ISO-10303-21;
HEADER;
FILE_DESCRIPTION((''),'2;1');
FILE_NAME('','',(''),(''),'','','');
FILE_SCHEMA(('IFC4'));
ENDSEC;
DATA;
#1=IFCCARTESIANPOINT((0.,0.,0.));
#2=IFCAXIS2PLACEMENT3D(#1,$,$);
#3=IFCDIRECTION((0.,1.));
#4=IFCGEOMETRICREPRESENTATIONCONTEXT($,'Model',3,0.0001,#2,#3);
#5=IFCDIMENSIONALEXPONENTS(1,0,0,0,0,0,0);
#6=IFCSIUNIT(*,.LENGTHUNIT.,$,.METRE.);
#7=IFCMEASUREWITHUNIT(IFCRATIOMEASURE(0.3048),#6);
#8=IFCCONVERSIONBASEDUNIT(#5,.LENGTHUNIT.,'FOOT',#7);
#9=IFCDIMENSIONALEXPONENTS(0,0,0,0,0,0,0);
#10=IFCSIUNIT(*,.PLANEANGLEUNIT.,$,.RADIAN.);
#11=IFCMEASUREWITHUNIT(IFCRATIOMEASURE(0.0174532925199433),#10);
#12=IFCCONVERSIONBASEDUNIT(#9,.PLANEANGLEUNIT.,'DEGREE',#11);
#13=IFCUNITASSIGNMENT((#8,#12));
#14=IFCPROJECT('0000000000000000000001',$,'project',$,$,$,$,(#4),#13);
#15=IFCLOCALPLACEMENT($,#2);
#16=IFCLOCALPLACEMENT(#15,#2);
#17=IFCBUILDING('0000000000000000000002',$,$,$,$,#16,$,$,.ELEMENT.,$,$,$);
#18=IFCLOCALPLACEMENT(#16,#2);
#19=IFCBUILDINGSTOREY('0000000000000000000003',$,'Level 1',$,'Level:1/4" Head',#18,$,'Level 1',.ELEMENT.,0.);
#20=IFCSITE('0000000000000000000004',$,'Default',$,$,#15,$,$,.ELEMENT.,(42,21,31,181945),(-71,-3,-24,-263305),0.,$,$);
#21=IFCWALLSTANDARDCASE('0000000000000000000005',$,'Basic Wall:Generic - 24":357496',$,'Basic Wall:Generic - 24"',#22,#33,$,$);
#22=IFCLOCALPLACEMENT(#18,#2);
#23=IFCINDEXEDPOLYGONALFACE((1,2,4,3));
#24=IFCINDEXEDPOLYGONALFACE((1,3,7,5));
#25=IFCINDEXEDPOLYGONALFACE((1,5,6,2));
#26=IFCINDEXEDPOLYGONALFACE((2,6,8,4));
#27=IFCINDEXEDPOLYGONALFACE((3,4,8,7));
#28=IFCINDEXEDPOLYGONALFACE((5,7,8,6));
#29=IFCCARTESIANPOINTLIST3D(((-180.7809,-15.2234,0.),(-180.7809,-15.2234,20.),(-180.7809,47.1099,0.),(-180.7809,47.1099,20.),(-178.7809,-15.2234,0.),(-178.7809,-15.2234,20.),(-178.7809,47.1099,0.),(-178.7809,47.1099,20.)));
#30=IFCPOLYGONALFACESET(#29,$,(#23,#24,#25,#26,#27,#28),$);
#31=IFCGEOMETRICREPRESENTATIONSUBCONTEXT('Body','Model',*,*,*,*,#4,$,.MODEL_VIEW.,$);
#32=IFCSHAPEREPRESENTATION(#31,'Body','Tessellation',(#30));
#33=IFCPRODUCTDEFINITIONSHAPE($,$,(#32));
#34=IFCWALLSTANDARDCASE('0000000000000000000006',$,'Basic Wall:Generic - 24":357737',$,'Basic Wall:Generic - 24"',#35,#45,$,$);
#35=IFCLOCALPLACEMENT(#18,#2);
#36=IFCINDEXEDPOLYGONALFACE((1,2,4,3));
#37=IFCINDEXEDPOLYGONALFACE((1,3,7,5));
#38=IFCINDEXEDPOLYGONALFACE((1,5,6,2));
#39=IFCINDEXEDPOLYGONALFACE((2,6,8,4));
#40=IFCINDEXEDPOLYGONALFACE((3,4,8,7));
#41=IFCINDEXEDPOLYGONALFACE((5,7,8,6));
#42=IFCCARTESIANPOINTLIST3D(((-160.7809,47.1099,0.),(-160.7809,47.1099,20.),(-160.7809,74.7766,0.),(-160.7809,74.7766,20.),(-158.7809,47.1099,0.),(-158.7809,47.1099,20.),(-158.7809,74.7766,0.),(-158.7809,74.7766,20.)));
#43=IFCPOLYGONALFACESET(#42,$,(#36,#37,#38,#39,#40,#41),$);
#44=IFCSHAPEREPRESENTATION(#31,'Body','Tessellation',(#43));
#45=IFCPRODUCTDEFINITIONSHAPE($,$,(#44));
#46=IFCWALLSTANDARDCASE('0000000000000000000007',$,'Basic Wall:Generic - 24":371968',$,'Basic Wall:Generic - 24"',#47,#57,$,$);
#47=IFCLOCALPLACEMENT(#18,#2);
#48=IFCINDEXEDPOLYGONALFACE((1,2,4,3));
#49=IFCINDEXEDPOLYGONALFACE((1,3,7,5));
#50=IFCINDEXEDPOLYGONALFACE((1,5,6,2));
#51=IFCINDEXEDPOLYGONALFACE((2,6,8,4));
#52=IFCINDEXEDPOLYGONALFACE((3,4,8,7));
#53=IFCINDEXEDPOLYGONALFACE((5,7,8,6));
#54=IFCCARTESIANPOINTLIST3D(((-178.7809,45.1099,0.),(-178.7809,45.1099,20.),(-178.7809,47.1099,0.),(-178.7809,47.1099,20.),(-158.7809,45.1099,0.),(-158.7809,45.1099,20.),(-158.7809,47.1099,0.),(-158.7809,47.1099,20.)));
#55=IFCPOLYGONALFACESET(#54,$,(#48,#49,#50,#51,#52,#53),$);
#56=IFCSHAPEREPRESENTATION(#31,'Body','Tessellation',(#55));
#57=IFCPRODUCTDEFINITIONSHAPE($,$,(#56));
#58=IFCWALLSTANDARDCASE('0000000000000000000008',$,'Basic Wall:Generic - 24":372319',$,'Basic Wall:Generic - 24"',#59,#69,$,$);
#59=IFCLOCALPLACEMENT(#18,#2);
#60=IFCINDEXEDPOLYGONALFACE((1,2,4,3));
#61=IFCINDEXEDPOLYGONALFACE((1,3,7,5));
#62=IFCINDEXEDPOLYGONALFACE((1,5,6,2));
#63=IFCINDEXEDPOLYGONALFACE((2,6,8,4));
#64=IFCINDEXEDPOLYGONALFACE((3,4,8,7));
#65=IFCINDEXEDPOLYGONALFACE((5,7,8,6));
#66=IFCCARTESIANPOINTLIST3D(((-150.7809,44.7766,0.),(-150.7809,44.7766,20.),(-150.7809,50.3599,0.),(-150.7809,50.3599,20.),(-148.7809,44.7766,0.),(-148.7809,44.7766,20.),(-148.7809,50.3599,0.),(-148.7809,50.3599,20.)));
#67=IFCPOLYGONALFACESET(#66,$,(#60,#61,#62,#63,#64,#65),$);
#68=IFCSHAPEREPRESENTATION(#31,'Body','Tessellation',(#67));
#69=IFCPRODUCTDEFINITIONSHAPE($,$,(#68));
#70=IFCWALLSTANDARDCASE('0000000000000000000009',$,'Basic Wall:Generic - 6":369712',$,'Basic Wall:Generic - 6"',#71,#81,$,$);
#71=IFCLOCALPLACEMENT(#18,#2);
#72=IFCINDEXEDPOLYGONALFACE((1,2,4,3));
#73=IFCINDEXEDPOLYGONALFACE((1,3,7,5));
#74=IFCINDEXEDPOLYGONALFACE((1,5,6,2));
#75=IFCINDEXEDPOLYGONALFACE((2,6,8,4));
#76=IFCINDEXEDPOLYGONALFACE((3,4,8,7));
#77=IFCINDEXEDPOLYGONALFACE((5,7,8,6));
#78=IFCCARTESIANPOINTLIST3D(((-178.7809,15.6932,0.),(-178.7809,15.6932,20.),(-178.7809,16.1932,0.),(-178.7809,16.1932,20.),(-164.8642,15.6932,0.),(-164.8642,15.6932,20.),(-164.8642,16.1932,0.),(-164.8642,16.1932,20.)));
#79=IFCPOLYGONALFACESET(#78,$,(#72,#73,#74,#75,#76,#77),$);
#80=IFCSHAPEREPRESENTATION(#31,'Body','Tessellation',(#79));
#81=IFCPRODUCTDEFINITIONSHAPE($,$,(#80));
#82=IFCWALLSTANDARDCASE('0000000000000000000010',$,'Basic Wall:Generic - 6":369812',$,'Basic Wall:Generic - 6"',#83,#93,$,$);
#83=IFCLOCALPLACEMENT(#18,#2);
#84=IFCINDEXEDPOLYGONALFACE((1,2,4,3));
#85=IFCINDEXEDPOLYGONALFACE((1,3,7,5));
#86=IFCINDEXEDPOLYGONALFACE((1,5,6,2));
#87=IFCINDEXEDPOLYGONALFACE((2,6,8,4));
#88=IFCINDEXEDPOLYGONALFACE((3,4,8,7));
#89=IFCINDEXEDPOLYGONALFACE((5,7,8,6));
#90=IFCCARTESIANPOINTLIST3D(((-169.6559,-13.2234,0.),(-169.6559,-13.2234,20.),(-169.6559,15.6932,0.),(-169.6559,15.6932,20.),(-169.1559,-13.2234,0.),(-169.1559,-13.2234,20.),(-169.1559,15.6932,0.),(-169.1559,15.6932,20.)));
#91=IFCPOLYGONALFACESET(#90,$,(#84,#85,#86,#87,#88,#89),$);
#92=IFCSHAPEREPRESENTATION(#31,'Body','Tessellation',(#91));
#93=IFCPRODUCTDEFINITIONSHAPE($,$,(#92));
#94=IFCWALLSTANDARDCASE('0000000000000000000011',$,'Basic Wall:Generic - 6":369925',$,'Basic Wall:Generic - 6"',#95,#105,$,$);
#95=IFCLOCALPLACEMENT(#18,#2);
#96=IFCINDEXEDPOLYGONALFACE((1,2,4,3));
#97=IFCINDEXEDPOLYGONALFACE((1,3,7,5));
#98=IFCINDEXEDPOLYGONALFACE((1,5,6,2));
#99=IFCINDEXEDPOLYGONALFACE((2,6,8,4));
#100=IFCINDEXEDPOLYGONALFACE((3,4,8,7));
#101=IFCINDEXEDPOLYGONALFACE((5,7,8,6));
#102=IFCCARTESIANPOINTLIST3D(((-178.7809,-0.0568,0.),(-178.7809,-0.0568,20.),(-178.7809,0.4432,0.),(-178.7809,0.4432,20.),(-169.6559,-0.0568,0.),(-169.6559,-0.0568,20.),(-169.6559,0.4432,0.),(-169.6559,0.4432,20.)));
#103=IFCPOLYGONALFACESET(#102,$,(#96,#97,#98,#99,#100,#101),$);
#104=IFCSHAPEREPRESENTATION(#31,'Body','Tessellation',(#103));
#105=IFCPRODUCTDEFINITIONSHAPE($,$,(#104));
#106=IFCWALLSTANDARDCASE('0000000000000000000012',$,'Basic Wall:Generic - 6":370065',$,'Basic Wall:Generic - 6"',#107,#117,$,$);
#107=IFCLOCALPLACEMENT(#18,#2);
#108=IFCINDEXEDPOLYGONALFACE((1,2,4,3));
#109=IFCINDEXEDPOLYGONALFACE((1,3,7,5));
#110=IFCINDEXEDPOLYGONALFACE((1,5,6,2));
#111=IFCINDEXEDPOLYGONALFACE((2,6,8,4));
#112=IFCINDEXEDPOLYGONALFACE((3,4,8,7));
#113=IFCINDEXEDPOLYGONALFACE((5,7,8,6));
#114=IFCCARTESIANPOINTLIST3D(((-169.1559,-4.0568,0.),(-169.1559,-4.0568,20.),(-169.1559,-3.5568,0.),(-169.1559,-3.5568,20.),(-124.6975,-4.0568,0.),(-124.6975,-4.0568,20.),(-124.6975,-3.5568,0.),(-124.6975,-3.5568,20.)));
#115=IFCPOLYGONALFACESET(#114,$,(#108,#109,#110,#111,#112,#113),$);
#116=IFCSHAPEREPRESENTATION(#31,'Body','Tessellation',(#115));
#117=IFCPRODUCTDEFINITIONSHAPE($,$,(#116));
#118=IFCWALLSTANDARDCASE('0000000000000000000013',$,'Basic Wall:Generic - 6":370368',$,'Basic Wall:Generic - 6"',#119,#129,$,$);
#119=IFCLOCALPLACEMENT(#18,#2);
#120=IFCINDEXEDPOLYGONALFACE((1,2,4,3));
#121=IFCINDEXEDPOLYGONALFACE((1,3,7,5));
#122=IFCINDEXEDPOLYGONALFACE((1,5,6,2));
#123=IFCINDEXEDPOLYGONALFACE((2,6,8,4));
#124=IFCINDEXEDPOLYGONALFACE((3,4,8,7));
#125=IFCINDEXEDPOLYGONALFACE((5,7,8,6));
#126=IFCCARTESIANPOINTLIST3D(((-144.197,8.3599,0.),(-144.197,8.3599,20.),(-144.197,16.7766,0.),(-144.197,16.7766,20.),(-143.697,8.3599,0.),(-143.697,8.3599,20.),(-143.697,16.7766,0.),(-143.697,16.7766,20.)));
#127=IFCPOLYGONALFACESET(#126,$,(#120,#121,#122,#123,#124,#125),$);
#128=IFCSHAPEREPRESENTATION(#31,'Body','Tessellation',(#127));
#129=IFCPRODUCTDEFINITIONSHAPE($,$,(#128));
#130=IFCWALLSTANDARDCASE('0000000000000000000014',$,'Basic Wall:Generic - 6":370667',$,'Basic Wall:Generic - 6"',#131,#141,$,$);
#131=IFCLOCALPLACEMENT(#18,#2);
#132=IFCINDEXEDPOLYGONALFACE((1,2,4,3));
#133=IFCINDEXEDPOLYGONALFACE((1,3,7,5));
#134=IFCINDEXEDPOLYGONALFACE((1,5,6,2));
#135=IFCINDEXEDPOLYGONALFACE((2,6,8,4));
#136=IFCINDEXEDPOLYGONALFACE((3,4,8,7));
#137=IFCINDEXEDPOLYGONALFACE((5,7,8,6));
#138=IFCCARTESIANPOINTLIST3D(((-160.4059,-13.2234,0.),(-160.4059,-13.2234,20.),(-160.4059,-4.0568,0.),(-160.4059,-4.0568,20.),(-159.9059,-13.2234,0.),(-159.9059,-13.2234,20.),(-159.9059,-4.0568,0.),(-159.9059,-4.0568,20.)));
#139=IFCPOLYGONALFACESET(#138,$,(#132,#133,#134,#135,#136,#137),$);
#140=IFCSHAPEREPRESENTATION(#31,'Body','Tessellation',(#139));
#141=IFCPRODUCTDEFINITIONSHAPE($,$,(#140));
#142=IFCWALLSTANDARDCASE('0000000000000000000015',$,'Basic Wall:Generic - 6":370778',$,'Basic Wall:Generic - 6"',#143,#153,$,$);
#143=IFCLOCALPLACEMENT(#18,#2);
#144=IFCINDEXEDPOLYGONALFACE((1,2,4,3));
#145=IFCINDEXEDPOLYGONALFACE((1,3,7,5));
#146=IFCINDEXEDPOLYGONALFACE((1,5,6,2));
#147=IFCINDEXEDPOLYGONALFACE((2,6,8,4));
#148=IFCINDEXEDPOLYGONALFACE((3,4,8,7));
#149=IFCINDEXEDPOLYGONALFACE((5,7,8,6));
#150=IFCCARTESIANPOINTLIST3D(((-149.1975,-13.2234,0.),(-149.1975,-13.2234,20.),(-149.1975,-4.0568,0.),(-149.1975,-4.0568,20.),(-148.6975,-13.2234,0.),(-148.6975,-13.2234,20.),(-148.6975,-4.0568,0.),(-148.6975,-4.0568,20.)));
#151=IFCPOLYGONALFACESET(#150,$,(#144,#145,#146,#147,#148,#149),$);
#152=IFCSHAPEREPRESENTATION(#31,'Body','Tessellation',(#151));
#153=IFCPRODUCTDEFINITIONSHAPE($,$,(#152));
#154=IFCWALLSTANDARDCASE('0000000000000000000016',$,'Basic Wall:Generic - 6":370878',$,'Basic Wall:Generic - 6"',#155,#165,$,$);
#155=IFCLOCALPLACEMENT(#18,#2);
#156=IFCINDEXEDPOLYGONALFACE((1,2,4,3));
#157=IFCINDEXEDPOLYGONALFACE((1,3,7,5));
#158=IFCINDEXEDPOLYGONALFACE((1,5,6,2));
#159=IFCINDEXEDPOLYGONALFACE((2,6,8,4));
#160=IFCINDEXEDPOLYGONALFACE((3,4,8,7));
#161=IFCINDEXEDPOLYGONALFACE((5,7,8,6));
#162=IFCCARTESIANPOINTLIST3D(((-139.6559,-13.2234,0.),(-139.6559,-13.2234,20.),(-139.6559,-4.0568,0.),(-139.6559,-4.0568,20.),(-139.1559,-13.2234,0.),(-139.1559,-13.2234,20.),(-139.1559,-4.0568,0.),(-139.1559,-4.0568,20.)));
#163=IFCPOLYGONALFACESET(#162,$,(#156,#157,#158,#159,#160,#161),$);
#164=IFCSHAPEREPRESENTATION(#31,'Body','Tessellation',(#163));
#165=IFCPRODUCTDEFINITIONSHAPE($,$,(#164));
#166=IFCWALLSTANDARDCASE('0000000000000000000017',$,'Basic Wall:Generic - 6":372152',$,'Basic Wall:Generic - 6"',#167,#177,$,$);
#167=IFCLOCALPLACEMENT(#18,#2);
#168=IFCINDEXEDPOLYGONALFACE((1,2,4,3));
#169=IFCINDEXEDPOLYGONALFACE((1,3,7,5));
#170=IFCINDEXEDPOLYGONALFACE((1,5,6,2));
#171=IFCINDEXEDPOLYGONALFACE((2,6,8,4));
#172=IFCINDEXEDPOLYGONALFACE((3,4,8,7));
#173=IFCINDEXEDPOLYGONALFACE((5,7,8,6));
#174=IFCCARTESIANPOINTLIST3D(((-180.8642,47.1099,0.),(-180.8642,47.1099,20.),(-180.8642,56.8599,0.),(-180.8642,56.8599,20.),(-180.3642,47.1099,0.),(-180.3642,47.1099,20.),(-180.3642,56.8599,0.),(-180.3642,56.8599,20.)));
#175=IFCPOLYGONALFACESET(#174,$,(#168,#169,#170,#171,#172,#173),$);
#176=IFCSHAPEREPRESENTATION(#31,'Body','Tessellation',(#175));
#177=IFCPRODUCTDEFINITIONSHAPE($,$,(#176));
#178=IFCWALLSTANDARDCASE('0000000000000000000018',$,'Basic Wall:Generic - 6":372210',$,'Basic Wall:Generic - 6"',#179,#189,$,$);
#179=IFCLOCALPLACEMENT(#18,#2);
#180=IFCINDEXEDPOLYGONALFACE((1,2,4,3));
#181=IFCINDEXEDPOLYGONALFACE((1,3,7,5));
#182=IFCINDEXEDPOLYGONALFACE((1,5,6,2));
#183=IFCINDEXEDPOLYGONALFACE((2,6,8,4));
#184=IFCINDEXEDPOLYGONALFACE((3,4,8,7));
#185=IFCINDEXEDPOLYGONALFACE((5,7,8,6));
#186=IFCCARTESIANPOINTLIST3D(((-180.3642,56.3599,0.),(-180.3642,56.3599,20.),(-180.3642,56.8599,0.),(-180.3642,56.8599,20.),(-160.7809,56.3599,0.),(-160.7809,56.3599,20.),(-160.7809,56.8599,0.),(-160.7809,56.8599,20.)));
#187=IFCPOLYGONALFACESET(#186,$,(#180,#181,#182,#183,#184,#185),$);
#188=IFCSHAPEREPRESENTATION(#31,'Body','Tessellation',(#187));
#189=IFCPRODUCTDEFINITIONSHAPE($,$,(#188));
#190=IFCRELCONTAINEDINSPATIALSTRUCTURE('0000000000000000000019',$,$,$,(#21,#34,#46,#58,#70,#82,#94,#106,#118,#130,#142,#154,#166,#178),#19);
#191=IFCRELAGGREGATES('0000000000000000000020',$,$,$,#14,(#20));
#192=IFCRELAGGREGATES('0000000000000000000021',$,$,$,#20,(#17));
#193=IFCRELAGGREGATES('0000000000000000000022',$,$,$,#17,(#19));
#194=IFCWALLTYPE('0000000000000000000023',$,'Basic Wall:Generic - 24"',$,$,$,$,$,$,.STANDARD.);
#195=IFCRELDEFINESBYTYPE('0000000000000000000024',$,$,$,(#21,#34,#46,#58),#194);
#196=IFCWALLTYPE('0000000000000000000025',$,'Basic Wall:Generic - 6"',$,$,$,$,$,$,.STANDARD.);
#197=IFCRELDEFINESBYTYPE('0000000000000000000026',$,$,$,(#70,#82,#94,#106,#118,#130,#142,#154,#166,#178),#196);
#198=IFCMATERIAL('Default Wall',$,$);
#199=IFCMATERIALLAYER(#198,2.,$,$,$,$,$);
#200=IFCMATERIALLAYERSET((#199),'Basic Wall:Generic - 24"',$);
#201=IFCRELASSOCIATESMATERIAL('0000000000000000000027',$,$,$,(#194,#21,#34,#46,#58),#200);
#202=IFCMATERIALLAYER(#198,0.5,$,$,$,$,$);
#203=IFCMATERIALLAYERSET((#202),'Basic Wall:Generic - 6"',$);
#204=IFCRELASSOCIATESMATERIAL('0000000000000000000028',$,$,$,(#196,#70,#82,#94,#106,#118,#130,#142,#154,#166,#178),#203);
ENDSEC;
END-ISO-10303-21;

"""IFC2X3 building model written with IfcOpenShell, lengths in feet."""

from ifc_helpers import new_model, entity, si_unit, converted_unit, direction, frame, frame_2d, origin, place, context, subcontext, project, spatial, rectangle, extrude, material, layer, layer_set, layer_usage, type_object, element, save


model = new_model("IFC2X3")

# Units and contexts
model_context = context("Model", 3, precision=0.0001, world=origin(), true_north=direction((0.0, 1.0)))
body_context = subcontext(model_context, "Body", "Model", "MODEL_VIEW")
ifc_project = project(units=[converted_unit("LENGTHUNIT", "FOOT", entity("IfcRatioMeasure", 0.3048), si_unit("LENGTHUNIT", "METRE"), dimensions=[1, 0, 0, 0, 0, 0, 0]), converted_unit("PLANEANGLEUNIT", "DEGREE", entity("IfcRatioMeasure", 0.0174532925199433), si_unit("PLANEANGLEUNIT", "RADIAN"), dimensions=[0, 0, 0, 0, 0, 0, 0])], contexts=[model_context])

# Site, building, storey
site_placement = place(None, origin())
site = spatial("IfcSite", under=ifc_project, at=site_placement, Name="Default", CompositionType="ELEMENT", RefLatitude=(42, 21, 31, 181945), RefLongitude=(-71, -3, -24, -263305), RefElevation=0.0)
building_placement = place(site_placement, origin())
building = spatial("IfcBuilding", under=site, at=building_placement, CompositionType="ELEMENT")
storey_placement = place(building_placement, origin())
storey = spatial("IfcBuildingStorey", under=building, at=storey_placement, Name="Level 1", ObjectType="Level:1/4\" Head", LongName="Level 1", CompositionType="ELEMENT", Elevation=0.0)

# Walls
ifc_material = material(Name="Default Wall")
ifc_layer_1 = layer(ifc_material, 2.0)
ifc_layer_set_1 = layer_set([ifc_layer_1], Name="Basic Wall:Generic - 24\"")
ifc_layer_usage_1 = layer_usage(ifc_layer_set_1, "AXIS2", "NEGATIVE", 1.0)
wall_type_1 = type_object("IfcWallType", Name="Basic Wall:Generic - 24\"", PredefinedType="STANDARD", material=ifc_layer_set_1)
wall_1_placement = place(storey_placement, frame((-179.7809, 47.1099, 0.0), z_axis=(0.0, 0.0, 1.0), x_axis=(0.0, -1.0, 0.0)))
element("IfcWallStandardCase", 1, at=wall_1_placement, inside=storey, type_object=wall_type_1, material=ifc_layer_usage_1, Name="Basic Wall:Generic - 24\":357496", ObjectType="Basic Wall:Generic - 24\"", context=body_context, shape_type="SweptSolid", body=[
    extrude(rectangle(XDim=62.3333, YDim=2.0, at=frame_2d((31.1667, 0.0), x_axis=(-1.0, 0.0))), origin(), (0.0, 0.0, 1.0), 20.0),
])
ifc_layer_usage_2 = layer_usage(ifc_layer_set_1, "AXIS2", "NEGATIVE", 1.0)
wall_2_placement = place(storey_placement, frame((-159.7809, 47.1099, 0.0), z_axis=(0.0, 0.0, 1.0), x_axis=(0.0, 1.0, 0.0)))
element("IfcWallStandardCase", 2, at=wall_2_placement, inside=storey, type_object=wall_type_1, material=ifc_layer_usage_2, Name="Basic Wall:Generic - 24\":357737", ObjectType="Basic Wall:Generic - 24\"", context=body_context, shape_type="SweptSolid", body=[
    extrude(rectangle(XDim=27.6667, YDim=2.0, at=frame_2d((13.8333, 0.0), x_axis=(-1.0, 0.0))), origin(), (0.0, 0.0, 1.0), 20.0),
])
ifc_layer_usage_3 = layer_usage(ifc_layer_set_1, "AXIS2", "NEGATIVE", 1.0)
wall_3_placement = place(storey_placement, frame((-178.7809, 46.1099, 0.0)))
element("IfcWallStandardCase", 3, at=wall_3_placement, inside=storey, type_object=wall_type_1, material=ifc_layer_usage_3, Name="Basic Wall:Generic - 24\":371968", ObjectType="Basic Wall:Generic - 24\"", context=body_context, shape_type="SweptSolid", body=[
    extrude(rectangle(XDim=20.0, YDim=2.0, at=frame_2d((10.0, 0.0), x_axis=(-1.0, 0.0))), origin(), (0.0, 0.0, 1.0), 20.0),
])
ifc_layer_usage_4 = layer_usage(ifc_layer_set_1, "AXIS2", "NEGATIVE", 1.0)
wall_4_placement = place(storey_placement, frame((-149.7809, 50.3599, 0.0), z_axis=(0.0, 0.0, 1.0), x_axis=(0.0, -1.0, 0.0)))
element("IfcWallStandardCase", 4, at=wall_4_placement, inside=storey, type_object=wall_type_1, material=ifc_layer_usage_4, Name="Basic Wall:Generic - 24\":372319", ObjectType="Basic Wall:Generic - 24\"", context=body_context, shape_type="SweptSolid", body=[
    extrude(rectangle(XDim=5.5833, YDim=2.0, at=frame_2d((2.7917, 0.0), x_axis=(-1.0, 0.0))), origin(), (0.0, 0.0, 1.0), 20.0),
])
ifc_layer_2 = layer(ifc_material, 0.5)
ifc_layer_set_2 = layer_set([ifc_layer_2], Name="Basic Wall:Generic - 6\"")
ifc_layer_usage_5 = layer_usage(ifc_layer_set_2, "AXIS2", "NEGATIVE", 0.25)
wall_type_2 = type_object("IfcWallType", Name="Basic Wall:Generic - 6\"", PredefinedType="STANDARD", material=ifc_layer_set_2)
wall_5_placement = place(storey_placement, frame((-178.7809, 15.9432, 0.0)))
element("IfcWallStandardCase", 5, at=wall_5_placement, inside=storey, type_object=wall_type_2, material=ifc_layer_usage_5, Name="Basic Wall:Generic - 6\":369712", ObjectType="Basic Wall:Generic - 6\"", context=body_context, shape_type="SweptSolid", body=[
    extrude(rectangle(XDim=13.9167, YDim=0.5, at=frame_2d((6.9583, 0.0), x_axis=(-1.0, 0.0))), origin(), (0.0, 0.0, 1.0), 20.0),
])
ifc_layer_usage_6 = layer_usage(ifc_layer_set_2, "AXIS2", "NEGATIVE", 0.25)
wall_6_placement = place(storey_placement, frame((-169.4059, 15.6932, 0.0), z_axis=(0.0, 0.0, 1.0), x_axis=(0.0, -1.0, 0.0)))
element("IfcWallStandardCase", 6, at=wall_6_placement, inside=storey, type_object=wall_type_2, material=ifc_layer_usage_6, Name="Basic Wall:Generic - 6\":369812", ObjectType="Basic Wall:Generic - 6\"", context=body_context, shape_type="SweptSolid", body=[
    extrude(rectangle(XDim=28.9167, YDim=0.5, at=frame_2d((14.4583, 0.0), x_axis=(-1.0, 0.0))), origin(), (0.0, 0.0, 1.0), 20.0),
])
ifc_layer_usage_7 = layer_usage(ifc_layer_set_2, "AXIS2", "NEGATIVE", 0.25)
wall_7_placement = place(storey_placement, frame((-178.7809, 0.1932, 0.0)))
element("IfcWallStandardCase", 7, at=wall_7_placement, inside=storey, type_object=wall_type_2, material=ifc_layer_usage_7, Name="Basic Wall:Generic - 6\":369925", ObjectType="Basic Wall:Generic - 6\"", context=body_context, shape_type="SweptSolid", body=[
    extrude(rectangle(XDim=9.125, YDim=0.5, at=frame_2d((4.5625, 0.0), x_axis=(-1.0, 0.0))), origin(), (0.0, 0.0, 1.0), 20.0),
])
ifc_layer_usage_8 = layer_usage(ifc_layer_set_2, "AXIS2", "NEGATIVE", 0.25)
wall_8_placement = place(storey_placement, frame((-169.1559, -3.8068, 0.0)))
element("IfcWallStandardCase", 8, at=wall_8_placement, inside=storey, type_object=wall_type_2, material=ifc_layer_usage_8, Name="Basic Wall:Generic - 6\":370065", ObjectType="Basic Wall:Generic - 6\"", context=body_context, shape_type="SweptSolid", body=[
    extrude(rectangle(XDim=44.4583, YDim=0.5, at=frame_2d((22.2292, 0.0), x_axis=(-1.0, 0.0))), origin(), (0.0, 0.0, 1.0), 20.0),
])
ifc_layer_usage_9 = layer_usage(ifc_layer_set_2, "AXIS2", "NEGATIVE", 0.25)
wall_9_placement = place(storey_placement, frame((-143.947, 8.3599, 0.0), z_axis=(0.0, 0.0, 1.0), x_axis=(0.0, 1.0, 0.0)))
element("IfcWallStandardCase", 9, at=wall_9_placement, inside=storey, type_object=wall_type_2, material=ifc_layer_usage_9, Name="Basic Wall:Generic - 6\":370368", ObjectType="Basic Wall:Generic - 6\"", context=body_context, shape_type="SweptSolid", body=[
    extrude(rectangle(XDim=8.4167, YDim=0.5, at=frame_2d((4.2083, 0.0), x_axis=(-1.0, 0.0))), origin(), (0.0, 0.0, 1.0), 20.0),
])
ifc_layer_usage_10 = layer_usage(ifc_layer_set_2, "AXIS2", "NEGATIVE", 0.25)
wall_10_placement = place(storey_placement, frame((-160.1559, -4.0568, 0.0), z_axis=(0.0, 0.0, 1.0), x_axis=(0.0, -1.0, 0.0)))
element("IfcWallStandardCase", 10, at=wall_10_placement, inside=storey, type_object=wall_type_2, material=ifc_layer_usage_10, Name="Basic Wall:Generic - 6\":370667", ObjectType="Basic Wall:Generic - 6\"", context=body_context, shape_type="SweptSolid", body=[
    extrude(rectangle(XDim=9.1667, YDim=0.5, at=frame_2d((4.5833, 0.0), x_axis=(-1.0, 0.0))), origin(), (0.0, 0.0, 1.0), 20.0),
])
ifc_layer_usage_11 = layer_usage(ifc_layer_set_2, "AXIS2", "NEGATIVE", 0.25)
wall_11_placement = place(storey_placement, frame((-148.9475, -4.0568, 0.0), z_axis=(0.0, 0.0, 1.0), x_axis=(0.0, -1.0, 0.0)))
element("IfcWallStandardCase", 11, at=wall_11_placement, inside=storey, type_object=wall_type_2, material=ifc_layer_usage_11, Name="Basic Wall:Generic - 6\":370778", ObjectType="Basic Wall:Generic - 6\"", context=body_context, shape_type="SweptSolid", body=[
    extrude(rectangle(XDim=9.1667, YDim=0.5, at=frame_2d((4.5833, 0.0), x_axis=(-1.0, 0.0))), origin(), (0.0, 0.0, 1.0), 20.0),
])
ifc_layer_usage_12 = layer_usage(ifc_layer_set_2, "AXIS2", "NEGATIVE", 0.25)
wall_12_placement = place(storey_placement, frame((-139.4059, -4.0568, 0.0), z_axis=(0.0, 0.0, 1.0), x_axis=(0.0, -1.0, 0.0)))
element("IfcWallStandardCase", 12, at=wall_12_placement, inside=storey, type_object=wall_type_2, material=ifc_layer_usage_12, Name="Basic Wall:Generic - 6\":370878", ObjectType="Basic Wall:Generic - 6\"", context=body_context, shape_type="SweptSolid", body=[
    extrude(rectangle(XDim=9.1667, YDim=0.5, at=frame_2d((4.5833, 0.0), x_axis=(-1.0, 0.0))), origin(), (0.0, 0.0, 1.0), 20.0),
])
ifc_layer_usage_13 = layer_usage(ifc_layer_set_2, "AXIS2", "NEGATIVE", 0.25)
wall_13_placement = place(storey_placement, frame((-180.6142, 47.1099, 0.0), z_axis=(0.0, 0.0, 1.0), x_axis=(0.0, 1.0, 0.0)))
element("IfcWallStandardCase", 13, at=wall_13_placement, inside=storey, type_object=wall_type_2, material=ifc_layer_usage_13, Name="Basic Wall:Generic - 6\":372152", ObjectType="Basic Wall:Generic - 6\"", context=body_context, shape_type="SweptSolid", body=[
    extrude(rectangle(XDim=9.75, YDim=0.5, at=frame_2d((4.875, 0.0), x_axis=(-1.0, 0.0))), origin(), (0.0, 0.0, 1.0), 20.0),
])
ifc_layer_usage_14 = layer_usage(ifc_layer_set_2, "AXIS2", "NEGATIVE", 0.25)
wall_14_placement = place(storey_placement, frame((-180.3642, 56.6099, 0.0)))
element("IfcWallStandardCase", 14, at=wall_14_placement, inside=storey, type_object=wall_type_2, material=ifc_layer_usage_14, Name="Basic Wall:Generic - 6\":372210", ObjectType="Basic Wall:Generic - 6\"", context=body_context, shape_type="SweptSolid", body=[
    extrude(rectangle(XDim=19.5833, YDim=0.5, at=frame_2d((9.7917, 0.0), x_axis=(-1.0, 0.0))), origin(), (0.0, 0.0, 1.0), 20.0),
])

save(model, "model.ifc")
